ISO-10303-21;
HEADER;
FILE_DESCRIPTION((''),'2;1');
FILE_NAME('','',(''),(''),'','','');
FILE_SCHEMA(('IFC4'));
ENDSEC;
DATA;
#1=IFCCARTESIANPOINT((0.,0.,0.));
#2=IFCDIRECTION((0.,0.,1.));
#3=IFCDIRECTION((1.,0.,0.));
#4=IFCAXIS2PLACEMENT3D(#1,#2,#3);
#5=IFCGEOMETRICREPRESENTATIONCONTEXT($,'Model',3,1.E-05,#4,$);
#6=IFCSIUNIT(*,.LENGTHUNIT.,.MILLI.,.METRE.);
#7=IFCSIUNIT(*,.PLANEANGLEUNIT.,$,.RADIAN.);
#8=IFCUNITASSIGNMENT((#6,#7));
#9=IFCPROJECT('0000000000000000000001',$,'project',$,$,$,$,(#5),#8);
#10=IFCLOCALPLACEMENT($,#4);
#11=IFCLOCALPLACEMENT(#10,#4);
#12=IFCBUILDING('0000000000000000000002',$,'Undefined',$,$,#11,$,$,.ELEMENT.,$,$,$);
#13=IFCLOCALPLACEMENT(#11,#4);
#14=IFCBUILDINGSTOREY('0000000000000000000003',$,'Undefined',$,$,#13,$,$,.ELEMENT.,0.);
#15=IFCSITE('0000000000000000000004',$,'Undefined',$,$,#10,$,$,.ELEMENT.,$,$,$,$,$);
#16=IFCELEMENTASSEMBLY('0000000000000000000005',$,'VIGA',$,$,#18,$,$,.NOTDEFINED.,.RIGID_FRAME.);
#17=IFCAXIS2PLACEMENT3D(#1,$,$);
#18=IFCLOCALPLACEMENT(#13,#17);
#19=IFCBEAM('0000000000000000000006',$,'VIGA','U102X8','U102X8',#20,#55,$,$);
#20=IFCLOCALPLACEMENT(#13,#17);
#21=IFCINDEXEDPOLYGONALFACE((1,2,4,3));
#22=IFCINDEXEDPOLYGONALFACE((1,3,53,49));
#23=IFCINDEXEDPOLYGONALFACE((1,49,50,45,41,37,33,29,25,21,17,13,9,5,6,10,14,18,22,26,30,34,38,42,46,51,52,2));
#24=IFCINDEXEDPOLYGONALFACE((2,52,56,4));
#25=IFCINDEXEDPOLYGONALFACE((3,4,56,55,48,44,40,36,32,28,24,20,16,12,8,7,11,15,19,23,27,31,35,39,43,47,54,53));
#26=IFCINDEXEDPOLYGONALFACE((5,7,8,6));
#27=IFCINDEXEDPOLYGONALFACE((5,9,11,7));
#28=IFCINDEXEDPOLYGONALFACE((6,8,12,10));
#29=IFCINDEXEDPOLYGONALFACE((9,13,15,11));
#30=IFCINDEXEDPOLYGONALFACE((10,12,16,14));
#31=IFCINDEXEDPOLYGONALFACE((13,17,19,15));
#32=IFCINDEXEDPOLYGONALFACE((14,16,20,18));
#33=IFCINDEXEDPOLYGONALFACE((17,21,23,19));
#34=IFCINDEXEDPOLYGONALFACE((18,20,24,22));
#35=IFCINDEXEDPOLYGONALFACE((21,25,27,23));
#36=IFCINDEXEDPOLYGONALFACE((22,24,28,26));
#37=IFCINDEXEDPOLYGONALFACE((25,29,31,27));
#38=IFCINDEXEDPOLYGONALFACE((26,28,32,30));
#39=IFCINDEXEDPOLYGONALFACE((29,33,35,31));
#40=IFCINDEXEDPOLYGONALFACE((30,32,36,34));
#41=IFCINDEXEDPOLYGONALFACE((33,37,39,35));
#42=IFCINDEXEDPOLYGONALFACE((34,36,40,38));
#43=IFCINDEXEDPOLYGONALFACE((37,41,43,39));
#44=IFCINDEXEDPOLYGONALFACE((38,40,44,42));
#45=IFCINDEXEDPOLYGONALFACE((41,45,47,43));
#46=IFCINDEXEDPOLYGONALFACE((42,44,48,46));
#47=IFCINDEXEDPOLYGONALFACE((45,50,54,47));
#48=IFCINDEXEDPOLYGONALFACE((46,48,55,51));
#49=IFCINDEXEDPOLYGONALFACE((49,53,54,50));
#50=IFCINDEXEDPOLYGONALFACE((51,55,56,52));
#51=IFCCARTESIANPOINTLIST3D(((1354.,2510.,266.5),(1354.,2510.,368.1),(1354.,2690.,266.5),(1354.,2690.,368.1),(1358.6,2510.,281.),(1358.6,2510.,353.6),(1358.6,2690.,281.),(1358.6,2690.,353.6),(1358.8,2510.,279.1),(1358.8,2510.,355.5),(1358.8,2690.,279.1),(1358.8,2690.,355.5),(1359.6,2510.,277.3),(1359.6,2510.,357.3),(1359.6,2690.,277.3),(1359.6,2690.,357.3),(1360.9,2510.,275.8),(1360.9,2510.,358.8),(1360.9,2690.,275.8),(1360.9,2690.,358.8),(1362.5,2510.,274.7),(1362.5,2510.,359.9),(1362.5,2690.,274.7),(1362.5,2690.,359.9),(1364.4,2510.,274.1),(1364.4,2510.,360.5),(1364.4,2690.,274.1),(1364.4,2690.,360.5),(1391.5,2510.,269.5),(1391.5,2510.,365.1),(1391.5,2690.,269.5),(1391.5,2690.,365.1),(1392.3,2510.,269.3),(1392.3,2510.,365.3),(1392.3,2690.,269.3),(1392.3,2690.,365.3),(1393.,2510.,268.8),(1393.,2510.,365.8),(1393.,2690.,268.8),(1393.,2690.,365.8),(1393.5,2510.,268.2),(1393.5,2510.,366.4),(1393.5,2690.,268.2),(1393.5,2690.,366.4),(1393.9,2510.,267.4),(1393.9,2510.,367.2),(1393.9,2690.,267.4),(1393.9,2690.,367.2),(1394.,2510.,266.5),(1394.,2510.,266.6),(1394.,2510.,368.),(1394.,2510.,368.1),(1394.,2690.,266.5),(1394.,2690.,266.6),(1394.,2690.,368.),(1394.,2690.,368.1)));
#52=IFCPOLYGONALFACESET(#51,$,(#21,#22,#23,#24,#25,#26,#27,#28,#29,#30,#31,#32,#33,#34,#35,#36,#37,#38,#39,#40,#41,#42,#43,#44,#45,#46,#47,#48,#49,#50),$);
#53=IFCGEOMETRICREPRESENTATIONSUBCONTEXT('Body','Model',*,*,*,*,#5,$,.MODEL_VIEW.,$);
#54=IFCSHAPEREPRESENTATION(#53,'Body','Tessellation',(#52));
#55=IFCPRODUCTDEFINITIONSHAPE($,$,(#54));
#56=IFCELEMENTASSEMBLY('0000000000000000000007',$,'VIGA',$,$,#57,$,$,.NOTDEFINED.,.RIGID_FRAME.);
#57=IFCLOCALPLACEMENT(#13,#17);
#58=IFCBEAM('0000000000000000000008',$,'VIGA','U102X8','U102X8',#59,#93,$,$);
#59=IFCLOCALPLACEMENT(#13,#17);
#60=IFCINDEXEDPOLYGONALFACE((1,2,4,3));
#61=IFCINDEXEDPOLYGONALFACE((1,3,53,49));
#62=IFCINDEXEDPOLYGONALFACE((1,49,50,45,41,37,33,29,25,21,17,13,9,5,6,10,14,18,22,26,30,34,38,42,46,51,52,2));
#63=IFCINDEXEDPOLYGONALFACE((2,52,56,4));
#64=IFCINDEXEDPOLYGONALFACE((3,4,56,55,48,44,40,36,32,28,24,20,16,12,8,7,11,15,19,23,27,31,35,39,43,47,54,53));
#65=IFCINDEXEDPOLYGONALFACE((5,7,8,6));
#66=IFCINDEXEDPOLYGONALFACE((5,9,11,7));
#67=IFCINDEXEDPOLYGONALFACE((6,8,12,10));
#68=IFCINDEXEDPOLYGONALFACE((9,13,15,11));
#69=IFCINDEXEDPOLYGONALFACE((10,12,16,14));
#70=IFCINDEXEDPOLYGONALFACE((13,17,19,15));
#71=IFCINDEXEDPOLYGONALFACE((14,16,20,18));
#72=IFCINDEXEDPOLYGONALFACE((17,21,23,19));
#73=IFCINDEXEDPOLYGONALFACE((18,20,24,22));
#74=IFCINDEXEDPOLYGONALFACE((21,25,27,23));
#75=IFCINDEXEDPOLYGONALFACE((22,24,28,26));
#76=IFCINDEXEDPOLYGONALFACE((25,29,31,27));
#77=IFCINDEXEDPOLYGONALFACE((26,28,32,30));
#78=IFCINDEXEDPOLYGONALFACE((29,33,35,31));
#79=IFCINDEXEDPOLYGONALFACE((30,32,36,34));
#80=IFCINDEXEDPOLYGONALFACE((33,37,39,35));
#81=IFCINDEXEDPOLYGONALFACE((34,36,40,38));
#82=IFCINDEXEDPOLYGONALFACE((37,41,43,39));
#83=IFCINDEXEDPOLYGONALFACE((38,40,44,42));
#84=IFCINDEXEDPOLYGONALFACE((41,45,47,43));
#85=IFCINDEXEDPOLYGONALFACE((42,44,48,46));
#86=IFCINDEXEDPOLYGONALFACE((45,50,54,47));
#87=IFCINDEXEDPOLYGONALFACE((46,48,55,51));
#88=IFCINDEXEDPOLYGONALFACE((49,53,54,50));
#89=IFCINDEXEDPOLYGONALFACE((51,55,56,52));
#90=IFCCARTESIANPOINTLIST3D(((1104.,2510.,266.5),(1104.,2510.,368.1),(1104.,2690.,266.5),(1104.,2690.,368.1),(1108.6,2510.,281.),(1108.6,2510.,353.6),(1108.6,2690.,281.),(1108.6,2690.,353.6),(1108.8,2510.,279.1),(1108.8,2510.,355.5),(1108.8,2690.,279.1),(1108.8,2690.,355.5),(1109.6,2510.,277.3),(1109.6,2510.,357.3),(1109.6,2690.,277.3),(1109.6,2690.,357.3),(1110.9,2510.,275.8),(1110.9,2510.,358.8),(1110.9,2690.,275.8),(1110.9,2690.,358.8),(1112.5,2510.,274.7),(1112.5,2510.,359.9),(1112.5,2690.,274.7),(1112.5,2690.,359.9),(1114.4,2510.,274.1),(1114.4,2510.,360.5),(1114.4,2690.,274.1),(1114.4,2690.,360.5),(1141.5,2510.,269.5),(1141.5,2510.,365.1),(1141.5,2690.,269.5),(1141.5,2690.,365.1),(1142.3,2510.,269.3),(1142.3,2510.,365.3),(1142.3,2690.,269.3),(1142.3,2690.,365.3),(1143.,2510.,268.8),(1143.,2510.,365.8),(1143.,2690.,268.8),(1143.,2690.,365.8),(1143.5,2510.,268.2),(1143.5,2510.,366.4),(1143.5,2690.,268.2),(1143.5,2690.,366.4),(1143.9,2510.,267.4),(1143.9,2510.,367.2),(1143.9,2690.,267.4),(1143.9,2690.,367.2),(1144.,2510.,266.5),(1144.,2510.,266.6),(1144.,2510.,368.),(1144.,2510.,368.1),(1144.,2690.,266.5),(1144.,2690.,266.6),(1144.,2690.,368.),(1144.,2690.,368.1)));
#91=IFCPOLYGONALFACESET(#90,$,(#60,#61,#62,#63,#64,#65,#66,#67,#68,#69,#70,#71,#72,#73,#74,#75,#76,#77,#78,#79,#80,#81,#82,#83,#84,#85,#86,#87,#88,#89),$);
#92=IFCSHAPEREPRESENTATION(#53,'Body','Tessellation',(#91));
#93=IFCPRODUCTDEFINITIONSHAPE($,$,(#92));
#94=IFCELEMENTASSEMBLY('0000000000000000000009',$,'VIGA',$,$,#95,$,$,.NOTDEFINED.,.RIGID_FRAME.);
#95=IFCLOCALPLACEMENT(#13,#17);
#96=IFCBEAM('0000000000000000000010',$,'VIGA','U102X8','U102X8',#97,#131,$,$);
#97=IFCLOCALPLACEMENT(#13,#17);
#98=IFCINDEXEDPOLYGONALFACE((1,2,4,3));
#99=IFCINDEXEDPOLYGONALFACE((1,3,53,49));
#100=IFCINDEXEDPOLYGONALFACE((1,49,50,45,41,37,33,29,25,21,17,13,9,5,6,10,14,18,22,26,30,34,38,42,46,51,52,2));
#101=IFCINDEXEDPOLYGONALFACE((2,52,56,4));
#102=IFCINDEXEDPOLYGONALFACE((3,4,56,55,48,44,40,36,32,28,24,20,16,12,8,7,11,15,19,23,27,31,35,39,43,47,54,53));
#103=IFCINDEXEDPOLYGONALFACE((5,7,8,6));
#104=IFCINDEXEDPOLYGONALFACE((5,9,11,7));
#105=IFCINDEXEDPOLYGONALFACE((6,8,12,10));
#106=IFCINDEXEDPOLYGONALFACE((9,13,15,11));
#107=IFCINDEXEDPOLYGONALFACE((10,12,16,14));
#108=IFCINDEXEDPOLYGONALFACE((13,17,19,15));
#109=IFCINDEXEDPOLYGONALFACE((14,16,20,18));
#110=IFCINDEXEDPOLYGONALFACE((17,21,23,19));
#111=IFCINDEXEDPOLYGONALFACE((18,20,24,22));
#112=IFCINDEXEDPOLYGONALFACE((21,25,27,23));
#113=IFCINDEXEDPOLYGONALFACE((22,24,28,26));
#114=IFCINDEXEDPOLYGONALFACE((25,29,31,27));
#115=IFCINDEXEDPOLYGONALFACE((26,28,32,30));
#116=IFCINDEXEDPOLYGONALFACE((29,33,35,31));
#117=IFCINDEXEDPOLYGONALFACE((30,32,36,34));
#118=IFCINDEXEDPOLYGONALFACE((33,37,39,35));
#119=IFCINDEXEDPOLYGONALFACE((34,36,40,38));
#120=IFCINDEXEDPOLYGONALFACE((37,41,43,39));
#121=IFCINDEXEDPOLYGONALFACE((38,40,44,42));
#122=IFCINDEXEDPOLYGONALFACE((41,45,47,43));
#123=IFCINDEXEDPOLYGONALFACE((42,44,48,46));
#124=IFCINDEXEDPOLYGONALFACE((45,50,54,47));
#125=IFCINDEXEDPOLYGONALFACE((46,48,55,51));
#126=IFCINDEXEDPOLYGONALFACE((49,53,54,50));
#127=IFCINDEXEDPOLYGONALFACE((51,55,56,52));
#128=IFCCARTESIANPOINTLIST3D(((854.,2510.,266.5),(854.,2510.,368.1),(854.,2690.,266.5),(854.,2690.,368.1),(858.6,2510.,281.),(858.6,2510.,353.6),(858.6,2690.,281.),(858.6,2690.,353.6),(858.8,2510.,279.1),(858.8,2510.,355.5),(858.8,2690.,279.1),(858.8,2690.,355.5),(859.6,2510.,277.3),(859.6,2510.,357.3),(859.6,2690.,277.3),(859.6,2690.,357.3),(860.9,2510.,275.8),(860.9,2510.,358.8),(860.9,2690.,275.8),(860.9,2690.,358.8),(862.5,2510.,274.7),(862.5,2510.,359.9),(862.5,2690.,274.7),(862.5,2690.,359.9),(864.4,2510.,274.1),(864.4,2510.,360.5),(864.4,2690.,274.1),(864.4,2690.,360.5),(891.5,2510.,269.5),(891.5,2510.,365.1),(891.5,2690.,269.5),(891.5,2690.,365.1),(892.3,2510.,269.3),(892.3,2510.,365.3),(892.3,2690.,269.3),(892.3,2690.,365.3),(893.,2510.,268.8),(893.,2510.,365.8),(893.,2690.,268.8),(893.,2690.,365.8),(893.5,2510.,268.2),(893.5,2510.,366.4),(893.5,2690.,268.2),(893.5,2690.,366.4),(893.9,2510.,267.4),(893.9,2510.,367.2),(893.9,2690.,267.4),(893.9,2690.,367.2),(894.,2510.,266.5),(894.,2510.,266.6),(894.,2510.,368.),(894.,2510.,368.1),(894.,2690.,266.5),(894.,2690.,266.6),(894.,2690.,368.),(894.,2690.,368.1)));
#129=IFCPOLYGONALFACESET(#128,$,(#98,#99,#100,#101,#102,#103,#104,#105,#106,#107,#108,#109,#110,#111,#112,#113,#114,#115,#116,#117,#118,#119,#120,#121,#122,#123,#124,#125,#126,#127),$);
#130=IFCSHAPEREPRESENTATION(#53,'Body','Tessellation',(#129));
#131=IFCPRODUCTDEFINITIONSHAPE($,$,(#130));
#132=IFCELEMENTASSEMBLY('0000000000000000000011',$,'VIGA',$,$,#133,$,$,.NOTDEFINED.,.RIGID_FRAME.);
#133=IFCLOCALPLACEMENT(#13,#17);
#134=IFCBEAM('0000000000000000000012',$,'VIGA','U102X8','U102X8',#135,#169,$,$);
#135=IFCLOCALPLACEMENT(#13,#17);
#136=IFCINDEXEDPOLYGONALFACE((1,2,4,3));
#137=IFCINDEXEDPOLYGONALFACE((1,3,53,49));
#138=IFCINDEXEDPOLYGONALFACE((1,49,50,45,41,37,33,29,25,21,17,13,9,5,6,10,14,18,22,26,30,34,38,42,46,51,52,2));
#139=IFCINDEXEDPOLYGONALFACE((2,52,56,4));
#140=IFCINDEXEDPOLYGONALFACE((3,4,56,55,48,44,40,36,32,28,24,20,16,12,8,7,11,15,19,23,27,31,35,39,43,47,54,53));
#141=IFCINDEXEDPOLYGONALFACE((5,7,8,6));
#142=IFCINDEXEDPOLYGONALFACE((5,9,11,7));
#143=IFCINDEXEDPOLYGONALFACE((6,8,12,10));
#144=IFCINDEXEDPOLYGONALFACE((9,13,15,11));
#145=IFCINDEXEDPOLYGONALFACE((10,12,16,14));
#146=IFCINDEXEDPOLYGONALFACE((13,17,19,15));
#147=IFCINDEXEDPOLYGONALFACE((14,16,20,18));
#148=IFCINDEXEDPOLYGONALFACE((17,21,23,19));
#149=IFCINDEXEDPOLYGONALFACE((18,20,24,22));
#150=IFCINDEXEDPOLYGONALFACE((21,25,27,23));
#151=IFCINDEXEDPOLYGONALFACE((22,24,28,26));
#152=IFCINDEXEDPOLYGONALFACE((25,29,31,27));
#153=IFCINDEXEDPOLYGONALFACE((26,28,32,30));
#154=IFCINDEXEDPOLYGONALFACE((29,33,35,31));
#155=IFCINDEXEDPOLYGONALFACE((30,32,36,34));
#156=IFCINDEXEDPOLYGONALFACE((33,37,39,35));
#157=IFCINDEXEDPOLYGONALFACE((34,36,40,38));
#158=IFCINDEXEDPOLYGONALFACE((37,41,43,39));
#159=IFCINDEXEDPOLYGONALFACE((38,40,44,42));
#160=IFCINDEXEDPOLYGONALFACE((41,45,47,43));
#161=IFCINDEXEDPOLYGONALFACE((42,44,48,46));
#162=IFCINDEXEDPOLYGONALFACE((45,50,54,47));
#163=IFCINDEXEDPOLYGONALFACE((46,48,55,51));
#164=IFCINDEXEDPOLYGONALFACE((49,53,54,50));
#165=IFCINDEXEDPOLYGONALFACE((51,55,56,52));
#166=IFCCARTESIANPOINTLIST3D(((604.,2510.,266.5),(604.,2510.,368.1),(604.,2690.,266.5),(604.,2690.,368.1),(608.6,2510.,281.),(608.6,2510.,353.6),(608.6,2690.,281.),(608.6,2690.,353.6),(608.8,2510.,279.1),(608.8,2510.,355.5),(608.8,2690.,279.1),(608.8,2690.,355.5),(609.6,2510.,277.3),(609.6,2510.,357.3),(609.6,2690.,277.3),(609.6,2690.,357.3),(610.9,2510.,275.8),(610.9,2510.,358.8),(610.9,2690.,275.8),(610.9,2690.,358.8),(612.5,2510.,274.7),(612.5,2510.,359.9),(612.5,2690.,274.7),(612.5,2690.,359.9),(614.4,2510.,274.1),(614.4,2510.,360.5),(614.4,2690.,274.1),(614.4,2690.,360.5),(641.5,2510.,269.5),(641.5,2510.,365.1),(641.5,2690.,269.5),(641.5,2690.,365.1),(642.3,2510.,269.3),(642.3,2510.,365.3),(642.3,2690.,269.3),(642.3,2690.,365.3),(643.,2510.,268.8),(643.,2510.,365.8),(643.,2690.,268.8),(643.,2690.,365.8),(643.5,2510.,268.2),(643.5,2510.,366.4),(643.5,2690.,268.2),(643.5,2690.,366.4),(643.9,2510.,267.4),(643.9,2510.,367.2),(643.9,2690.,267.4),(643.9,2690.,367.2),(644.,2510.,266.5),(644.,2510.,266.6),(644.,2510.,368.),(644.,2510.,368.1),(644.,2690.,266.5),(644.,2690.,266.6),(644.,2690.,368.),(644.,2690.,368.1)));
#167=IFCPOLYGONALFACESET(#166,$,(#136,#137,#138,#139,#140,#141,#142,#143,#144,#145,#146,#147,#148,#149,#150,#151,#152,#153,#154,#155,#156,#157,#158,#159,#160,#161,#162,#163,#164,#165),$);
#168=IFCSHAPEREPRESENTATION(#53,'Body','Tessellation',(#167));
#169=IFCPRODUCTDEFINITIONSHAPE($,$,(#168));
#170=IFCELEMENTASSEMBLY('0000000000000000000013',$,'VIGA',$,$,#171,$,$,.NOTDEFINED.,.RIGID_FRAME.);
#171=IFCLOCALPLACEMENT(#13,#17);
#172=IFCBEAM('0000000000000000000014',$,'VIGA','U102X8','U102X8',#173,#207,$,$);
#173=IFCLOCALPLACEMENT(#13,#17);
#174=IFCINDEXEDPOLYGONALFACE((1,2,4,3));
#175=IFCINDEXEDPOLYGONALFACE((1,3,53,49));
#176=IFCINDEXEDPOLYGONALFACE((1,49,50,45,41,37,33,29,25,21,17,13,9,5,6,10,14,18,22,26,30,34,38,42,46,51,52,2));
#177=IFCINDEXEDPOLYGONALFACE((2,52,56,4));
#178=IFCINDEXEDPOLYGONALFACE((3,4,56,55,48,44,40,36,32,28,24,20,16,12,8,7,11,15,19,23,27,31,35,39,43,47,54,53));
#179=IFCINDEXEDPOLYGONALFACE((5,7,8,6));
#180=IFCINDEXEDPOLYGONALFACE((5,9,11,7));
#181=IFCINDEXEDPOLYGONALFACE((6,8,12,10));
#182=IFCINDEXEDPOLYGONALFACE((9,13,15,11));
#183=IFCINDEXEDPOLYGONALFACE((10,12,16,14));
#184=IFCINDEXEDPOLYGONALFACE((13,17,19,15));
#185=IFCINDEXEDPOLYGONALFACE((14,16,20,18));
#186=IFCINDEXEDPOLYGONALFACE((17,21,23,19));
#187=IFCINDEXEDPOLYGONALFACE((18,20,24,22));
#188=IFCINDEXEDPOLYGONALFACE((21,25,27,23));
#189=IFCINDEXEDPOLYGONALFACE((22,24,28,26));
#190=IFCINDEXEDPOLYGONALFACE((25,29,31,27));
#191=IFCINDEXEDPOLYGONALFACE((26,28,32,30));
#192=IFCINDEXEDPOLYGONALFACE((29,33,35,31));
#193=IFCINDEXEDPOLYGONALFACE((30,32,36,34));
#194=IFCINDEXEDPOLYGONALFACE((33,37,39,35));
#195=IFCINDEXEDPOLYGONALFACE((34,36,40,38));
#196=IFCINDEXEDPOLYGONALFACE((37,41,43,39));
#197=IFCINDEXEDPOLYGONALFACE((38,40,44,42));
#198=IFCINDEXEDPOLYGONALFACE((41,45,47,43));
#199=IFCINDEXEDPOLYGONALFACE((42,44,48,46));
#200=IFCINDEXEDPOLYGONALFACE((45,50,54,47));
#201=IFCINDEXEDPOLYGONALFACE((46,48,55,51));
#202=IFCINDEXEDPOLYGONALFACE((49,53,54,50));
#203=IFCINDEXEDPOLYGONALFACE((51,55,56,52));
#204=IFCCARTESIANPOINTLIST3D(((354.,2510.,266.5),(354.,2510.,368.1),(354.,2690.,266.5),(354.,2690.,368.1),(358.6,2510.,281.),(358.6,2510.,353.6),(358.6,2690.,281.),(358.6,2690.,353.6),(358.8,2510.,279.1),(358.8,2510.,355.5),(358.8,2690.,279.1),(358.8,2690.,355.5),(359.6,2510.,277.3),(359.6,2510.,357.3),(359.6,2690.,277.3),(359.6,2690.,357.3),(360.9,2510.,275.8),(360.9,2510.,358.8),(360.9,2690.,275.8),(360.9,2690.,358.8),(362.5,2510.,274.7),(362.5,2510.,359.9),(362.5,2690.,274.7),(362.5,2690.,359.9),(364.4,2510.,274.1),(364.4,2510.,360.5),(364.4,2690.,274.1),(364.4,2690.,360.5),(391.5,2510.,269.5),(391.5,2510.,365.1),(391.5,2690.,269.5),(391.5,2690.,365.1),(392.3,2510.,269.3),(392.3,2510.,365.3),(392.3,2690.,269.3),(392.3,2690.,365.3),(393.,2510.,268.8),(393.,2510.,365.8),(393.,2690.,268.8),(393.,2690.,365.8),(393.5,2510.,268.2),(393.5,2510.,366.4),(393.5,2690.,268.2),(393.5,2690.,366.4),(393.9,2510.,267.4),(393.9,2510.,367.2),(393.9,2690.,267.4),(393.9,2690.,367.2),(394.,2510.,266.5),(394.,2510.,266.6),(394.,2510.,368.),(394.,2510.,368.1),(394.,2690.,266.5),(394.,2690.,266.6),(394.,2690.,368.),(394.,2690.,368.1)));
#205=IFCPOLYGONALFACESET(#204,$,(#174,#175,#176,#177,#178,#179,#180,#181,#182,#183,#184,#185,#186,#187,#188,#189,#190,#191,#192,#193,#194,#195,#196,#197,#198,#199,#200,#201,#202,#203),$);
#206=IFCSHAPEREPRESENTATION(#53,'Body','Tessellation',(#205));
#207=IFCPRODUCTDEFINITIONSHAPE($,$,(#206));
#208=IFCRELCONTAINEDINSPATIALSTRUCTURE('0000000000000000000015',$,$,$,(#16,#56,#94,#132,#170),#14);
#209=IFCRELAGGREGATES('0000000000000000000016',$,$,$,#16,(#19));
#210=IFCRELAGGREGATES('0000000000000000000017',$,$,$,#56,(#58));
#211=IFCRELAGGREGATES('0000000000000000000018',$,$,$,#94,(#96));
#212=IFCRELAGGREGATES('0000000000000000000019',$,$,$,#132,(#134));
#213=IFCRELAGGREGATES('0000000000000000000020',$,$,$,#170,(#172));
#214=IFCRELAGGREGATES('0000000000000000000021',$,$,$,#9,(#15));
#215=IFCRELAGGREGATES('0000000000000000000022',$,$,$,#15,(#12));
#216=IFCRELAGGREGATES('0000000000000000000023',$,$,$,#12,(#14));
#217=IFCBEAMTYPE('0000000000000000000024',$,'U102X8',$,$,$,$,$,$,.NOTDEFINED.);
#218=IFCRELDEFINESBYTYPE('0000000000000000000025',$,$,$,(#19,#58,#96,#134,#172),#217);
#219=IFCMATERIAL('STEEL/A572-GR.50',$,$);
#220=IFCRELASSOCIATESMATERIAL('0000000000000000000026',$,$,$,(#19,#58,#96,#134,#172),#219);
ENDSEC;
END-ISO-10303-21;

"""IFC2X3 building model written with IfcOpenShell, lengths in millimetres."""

from ifc_helpers import new_model, si_unit, frame, origin_with_axes, origin_2d_with_axis, place, context, subcontext, project, spatial, u_section, extrude, material, type_object, element, aggregate, save


model = new_model("IFC2X3")

# Units and contexts
model_context = context("Model", 3, precision=1e-05, world=origin_with_axes())
body_context = subcontext(model_context, "Body", "Model", "MODEL_VIEW")
ifc_project = project(units=[si_unit("LENGTHUNIT", "METRE", prefix="MILLI"), si_unit("PLANEANGLEUNIT", "RADIAN")], contexts=[model_context])

# Site, building, storey
site_placement = place(None, origin_with_axes())
site = spatial("IfcSite", under=ifc_project, at=site_placement, Name="Undefined", CompositionType="ELEMENT")
building_placement = place(site_placement, origin_with_axes())
building = spatial("IfcBuilding", under=site, at=building_placement, Name="Undefined", CompositionType="ELEMENT")
storey_placement = place(building_placement, origin_with_axes())
storey = spatial("IfcBuildingStorey", under=building, at=storey_placement, Name="Undefined", CompositionType="ELEMENT", Elevation=0.0)

# Element assemblies, beams
ifc_material_1 = material(Name="STEEL/A572-GR.50")
beam_type_1 = type_object("IfcBeamType", Name="U102X8", PredefinedType="NOTDEFINED")
assembly_1_placement = place(storey_placement, origin_with_axes())
assembly_1 = element("IfcElementAssembly", 1, at=assembly_1_placement, inside=storey, Name="VIGA", AssemblyPlace="NOTDEFINED", PredefinedType="RIGID_FRAME")
beam_1_placement = place(assembly_1_placement, frame((1374.0, 2510.0, 317.3), z_axis=(0.0, 0.0, 1.0), x_axis=(0.0, 1.0, 0.0)))
beam_1 = element("IfcBeam", 2, at=beam_1_placement, type_object=beam_type_1, material=ifc_material_1, Name="VIGA", Description="U102X8", ObjectType="U102X8", context=body_context, shape_type="SweptSolid", body=[
    extrude(u_section(Depth=101.6, FlangeWidth=40.0, WebThickness=4.6, FlangeThickness=6.0, FilletRadius=7.0, EdgeRadius=3.0, FlangeSlope=0.16839, at=origin_2d_with_axis()), frame((180.0, 0.0, 0.0), z_axis=(-1.0, 0.0, 0.0), x_axis=(0.0, -1.0, 0.0)), (0.0, 0.0, 1.0), 180.0),
])
aggregate(assembly_1, [beam_1])
assembly_2_placement = place(storey_placement, origin_with_axes())
assembly_2 = element("IfcElementAssembly", 3, at=assembly_2_placement, inside=storey, Name="VIGA", AssemblyPlace="NOTDEFINED", PredefinedType="RIGID_FRAME")
beam_2_placement = place(assembly_2_placement, frame((1124.0, 2510.0, 317.3), z_axis=(0.0, 0.0, 1.0), x_axis=(0.0, 1.0, 0.0)))
beam_2 = element("IfcBeam", 4, at=beam_2_placement, type_object=beam_type_1, material=ifc_material_1, Name="VIGA", Description="U102X8", ObjectType="U102X8", context=body_context, shape_type="SweptSolid", body=[
    extrude(u_section(Depth=101.6, FlangeWidth=40.0, WebThickness=4.6, FlangeThickness=6.0, FilletRadius=7.0, EdgeRadius=3.0, FlangeSlope=0.16839, at=origin_2d_with_axis()), frame((180.0, 0.0, 0.0), z_axis=(-1.0, 0.0, 0.0), x_axis=(0.0, -1.0, 0.0)), (0.0, 0.0, 1.0), 180.0),
])
aggregate(assembly_2, [beam_2])
assembly_3_placement = place(storey_placement, origin_with_axes())
assembly_3 = element("IfcElementAssembly", 5, at=assembly_3_placement, inside=storey, Name="VIGA", AssemblyPlace="NOTDEFINED", PredefinedType="RIGID_FRAME")
beam_3_placement = place(assembly_3_placement, frame((874.0, 2510.0, 317.3), z_axis=(0.0, 0.0, 1.0), x_axis=(0.0, 1.0, 0.0)))
beam_3 = element("IfcBeam", 6, at=beam_3_placement, type_object=beam_type_1, material=ifc_material_1, Name="VIGA", Description="U102X8", ObjectType="U102X8", context=body_context, shape_type="SweptSolid", body=[
    extrude(u_section(Depth=101.6, FlangeWidth=40.0, WebThickness=4.6, FlangeThickness=6.0, FilletRadius=7.0, EdgeRadius=3.0, FlangeSlope=0.16839, at=origin_2d_with_axis()), frame((180.0, 0.0, 0.0), z_axis=(-1.0, 0.0, 0.0), x_axis=(0.0, -1.0, 0.0)), (0.0, 0.0, 1.0), 180.0),
])
aggregate(assembly_3, [beam_3])
assembly_4_placement = place(storey_placement, origin_with_axes())
assembly_4 = element("IfcElementAssembly", 7, at=assembly_4_placement, inside=storey, Name="VIGA", AssemblyPlace="NOTDEFINED", PredefinedType="RIGID_FRAME")
beam_4_placement = place(assembly_4_placement, frame((624.0, 2510.0, 317.3), z_axis=(0.0, 0.0, 1.0), x_axis=(0.0, 1.0, 0.0)))
beam_4 = element("IfcBeam", 8, at=beam_4_placement, type_object=beam_type_1, material=ifc_material_1, Name="VIGA", Description="U102X8", ObjectType="U102X8", context=body_context, shape_type="SweptSolid", body=[
    extrude(u_section(Depth=101.6, FlangeWidth=40.0, WebThickness=4.6, FlangeThickness=6.0, FilletRadius=7.0, EdgeRadius=3.0, FlangeSlope=0.16839, at=origin_2d_with_axis()), frame((180.0, 0.0, 0.0), z_axis=(-1.0, 0.0, 0.0), x_axis=(0.0, -1.0, 0.0)), (0.0, 0.0, 1.0), 180.0),
])
aggregate(assembly_4, [beam_4])
assembly_5_placement = place(storey_placement, origin_with_axes())
assembly_5 = element("IfcElementAssembly", 9, at=assembly_5_placement, inside=storey, Name="VIGA", AssemblyPlace="NOTDEFINED", PredefinedType="RIGID_FRAME")
beam_5_placement = place(assembly_5_placement, frame((374.0, 2510.0, 317.3), z_axis=(0.0, 0.0, 1.0), x_axis=(0.0, 1.0, 0.0)))
beam_5 = element("IfcBeam", 10, at=beam_5_placement, type_object=beam_type_1, material=ifc_material_1, Name="VIGA", Description="U102X8", ObjectType="U102X8", context=body_context, shape_type="SweptSolid", body=[
    extrude(u_section(Depth=101.6, FlangeWidth=40.0, WebThickness=4.6, FlangeThickness=6.0, FilletRadius=7.0, EdgeRadius=3.0, FlangeSlope=0.16839, at=origin_2d_with_axis()), frame((180.0, 0.0, 0.0), z_axis=(-1.0, 0.0, 0.0), x_axis=(0.0, -1.0, 0.0)), (0.0, 0.0, 1.0), 180.0),
])
aggregate(assembly_5, [beam_5])

save(model, "model.ifc")
